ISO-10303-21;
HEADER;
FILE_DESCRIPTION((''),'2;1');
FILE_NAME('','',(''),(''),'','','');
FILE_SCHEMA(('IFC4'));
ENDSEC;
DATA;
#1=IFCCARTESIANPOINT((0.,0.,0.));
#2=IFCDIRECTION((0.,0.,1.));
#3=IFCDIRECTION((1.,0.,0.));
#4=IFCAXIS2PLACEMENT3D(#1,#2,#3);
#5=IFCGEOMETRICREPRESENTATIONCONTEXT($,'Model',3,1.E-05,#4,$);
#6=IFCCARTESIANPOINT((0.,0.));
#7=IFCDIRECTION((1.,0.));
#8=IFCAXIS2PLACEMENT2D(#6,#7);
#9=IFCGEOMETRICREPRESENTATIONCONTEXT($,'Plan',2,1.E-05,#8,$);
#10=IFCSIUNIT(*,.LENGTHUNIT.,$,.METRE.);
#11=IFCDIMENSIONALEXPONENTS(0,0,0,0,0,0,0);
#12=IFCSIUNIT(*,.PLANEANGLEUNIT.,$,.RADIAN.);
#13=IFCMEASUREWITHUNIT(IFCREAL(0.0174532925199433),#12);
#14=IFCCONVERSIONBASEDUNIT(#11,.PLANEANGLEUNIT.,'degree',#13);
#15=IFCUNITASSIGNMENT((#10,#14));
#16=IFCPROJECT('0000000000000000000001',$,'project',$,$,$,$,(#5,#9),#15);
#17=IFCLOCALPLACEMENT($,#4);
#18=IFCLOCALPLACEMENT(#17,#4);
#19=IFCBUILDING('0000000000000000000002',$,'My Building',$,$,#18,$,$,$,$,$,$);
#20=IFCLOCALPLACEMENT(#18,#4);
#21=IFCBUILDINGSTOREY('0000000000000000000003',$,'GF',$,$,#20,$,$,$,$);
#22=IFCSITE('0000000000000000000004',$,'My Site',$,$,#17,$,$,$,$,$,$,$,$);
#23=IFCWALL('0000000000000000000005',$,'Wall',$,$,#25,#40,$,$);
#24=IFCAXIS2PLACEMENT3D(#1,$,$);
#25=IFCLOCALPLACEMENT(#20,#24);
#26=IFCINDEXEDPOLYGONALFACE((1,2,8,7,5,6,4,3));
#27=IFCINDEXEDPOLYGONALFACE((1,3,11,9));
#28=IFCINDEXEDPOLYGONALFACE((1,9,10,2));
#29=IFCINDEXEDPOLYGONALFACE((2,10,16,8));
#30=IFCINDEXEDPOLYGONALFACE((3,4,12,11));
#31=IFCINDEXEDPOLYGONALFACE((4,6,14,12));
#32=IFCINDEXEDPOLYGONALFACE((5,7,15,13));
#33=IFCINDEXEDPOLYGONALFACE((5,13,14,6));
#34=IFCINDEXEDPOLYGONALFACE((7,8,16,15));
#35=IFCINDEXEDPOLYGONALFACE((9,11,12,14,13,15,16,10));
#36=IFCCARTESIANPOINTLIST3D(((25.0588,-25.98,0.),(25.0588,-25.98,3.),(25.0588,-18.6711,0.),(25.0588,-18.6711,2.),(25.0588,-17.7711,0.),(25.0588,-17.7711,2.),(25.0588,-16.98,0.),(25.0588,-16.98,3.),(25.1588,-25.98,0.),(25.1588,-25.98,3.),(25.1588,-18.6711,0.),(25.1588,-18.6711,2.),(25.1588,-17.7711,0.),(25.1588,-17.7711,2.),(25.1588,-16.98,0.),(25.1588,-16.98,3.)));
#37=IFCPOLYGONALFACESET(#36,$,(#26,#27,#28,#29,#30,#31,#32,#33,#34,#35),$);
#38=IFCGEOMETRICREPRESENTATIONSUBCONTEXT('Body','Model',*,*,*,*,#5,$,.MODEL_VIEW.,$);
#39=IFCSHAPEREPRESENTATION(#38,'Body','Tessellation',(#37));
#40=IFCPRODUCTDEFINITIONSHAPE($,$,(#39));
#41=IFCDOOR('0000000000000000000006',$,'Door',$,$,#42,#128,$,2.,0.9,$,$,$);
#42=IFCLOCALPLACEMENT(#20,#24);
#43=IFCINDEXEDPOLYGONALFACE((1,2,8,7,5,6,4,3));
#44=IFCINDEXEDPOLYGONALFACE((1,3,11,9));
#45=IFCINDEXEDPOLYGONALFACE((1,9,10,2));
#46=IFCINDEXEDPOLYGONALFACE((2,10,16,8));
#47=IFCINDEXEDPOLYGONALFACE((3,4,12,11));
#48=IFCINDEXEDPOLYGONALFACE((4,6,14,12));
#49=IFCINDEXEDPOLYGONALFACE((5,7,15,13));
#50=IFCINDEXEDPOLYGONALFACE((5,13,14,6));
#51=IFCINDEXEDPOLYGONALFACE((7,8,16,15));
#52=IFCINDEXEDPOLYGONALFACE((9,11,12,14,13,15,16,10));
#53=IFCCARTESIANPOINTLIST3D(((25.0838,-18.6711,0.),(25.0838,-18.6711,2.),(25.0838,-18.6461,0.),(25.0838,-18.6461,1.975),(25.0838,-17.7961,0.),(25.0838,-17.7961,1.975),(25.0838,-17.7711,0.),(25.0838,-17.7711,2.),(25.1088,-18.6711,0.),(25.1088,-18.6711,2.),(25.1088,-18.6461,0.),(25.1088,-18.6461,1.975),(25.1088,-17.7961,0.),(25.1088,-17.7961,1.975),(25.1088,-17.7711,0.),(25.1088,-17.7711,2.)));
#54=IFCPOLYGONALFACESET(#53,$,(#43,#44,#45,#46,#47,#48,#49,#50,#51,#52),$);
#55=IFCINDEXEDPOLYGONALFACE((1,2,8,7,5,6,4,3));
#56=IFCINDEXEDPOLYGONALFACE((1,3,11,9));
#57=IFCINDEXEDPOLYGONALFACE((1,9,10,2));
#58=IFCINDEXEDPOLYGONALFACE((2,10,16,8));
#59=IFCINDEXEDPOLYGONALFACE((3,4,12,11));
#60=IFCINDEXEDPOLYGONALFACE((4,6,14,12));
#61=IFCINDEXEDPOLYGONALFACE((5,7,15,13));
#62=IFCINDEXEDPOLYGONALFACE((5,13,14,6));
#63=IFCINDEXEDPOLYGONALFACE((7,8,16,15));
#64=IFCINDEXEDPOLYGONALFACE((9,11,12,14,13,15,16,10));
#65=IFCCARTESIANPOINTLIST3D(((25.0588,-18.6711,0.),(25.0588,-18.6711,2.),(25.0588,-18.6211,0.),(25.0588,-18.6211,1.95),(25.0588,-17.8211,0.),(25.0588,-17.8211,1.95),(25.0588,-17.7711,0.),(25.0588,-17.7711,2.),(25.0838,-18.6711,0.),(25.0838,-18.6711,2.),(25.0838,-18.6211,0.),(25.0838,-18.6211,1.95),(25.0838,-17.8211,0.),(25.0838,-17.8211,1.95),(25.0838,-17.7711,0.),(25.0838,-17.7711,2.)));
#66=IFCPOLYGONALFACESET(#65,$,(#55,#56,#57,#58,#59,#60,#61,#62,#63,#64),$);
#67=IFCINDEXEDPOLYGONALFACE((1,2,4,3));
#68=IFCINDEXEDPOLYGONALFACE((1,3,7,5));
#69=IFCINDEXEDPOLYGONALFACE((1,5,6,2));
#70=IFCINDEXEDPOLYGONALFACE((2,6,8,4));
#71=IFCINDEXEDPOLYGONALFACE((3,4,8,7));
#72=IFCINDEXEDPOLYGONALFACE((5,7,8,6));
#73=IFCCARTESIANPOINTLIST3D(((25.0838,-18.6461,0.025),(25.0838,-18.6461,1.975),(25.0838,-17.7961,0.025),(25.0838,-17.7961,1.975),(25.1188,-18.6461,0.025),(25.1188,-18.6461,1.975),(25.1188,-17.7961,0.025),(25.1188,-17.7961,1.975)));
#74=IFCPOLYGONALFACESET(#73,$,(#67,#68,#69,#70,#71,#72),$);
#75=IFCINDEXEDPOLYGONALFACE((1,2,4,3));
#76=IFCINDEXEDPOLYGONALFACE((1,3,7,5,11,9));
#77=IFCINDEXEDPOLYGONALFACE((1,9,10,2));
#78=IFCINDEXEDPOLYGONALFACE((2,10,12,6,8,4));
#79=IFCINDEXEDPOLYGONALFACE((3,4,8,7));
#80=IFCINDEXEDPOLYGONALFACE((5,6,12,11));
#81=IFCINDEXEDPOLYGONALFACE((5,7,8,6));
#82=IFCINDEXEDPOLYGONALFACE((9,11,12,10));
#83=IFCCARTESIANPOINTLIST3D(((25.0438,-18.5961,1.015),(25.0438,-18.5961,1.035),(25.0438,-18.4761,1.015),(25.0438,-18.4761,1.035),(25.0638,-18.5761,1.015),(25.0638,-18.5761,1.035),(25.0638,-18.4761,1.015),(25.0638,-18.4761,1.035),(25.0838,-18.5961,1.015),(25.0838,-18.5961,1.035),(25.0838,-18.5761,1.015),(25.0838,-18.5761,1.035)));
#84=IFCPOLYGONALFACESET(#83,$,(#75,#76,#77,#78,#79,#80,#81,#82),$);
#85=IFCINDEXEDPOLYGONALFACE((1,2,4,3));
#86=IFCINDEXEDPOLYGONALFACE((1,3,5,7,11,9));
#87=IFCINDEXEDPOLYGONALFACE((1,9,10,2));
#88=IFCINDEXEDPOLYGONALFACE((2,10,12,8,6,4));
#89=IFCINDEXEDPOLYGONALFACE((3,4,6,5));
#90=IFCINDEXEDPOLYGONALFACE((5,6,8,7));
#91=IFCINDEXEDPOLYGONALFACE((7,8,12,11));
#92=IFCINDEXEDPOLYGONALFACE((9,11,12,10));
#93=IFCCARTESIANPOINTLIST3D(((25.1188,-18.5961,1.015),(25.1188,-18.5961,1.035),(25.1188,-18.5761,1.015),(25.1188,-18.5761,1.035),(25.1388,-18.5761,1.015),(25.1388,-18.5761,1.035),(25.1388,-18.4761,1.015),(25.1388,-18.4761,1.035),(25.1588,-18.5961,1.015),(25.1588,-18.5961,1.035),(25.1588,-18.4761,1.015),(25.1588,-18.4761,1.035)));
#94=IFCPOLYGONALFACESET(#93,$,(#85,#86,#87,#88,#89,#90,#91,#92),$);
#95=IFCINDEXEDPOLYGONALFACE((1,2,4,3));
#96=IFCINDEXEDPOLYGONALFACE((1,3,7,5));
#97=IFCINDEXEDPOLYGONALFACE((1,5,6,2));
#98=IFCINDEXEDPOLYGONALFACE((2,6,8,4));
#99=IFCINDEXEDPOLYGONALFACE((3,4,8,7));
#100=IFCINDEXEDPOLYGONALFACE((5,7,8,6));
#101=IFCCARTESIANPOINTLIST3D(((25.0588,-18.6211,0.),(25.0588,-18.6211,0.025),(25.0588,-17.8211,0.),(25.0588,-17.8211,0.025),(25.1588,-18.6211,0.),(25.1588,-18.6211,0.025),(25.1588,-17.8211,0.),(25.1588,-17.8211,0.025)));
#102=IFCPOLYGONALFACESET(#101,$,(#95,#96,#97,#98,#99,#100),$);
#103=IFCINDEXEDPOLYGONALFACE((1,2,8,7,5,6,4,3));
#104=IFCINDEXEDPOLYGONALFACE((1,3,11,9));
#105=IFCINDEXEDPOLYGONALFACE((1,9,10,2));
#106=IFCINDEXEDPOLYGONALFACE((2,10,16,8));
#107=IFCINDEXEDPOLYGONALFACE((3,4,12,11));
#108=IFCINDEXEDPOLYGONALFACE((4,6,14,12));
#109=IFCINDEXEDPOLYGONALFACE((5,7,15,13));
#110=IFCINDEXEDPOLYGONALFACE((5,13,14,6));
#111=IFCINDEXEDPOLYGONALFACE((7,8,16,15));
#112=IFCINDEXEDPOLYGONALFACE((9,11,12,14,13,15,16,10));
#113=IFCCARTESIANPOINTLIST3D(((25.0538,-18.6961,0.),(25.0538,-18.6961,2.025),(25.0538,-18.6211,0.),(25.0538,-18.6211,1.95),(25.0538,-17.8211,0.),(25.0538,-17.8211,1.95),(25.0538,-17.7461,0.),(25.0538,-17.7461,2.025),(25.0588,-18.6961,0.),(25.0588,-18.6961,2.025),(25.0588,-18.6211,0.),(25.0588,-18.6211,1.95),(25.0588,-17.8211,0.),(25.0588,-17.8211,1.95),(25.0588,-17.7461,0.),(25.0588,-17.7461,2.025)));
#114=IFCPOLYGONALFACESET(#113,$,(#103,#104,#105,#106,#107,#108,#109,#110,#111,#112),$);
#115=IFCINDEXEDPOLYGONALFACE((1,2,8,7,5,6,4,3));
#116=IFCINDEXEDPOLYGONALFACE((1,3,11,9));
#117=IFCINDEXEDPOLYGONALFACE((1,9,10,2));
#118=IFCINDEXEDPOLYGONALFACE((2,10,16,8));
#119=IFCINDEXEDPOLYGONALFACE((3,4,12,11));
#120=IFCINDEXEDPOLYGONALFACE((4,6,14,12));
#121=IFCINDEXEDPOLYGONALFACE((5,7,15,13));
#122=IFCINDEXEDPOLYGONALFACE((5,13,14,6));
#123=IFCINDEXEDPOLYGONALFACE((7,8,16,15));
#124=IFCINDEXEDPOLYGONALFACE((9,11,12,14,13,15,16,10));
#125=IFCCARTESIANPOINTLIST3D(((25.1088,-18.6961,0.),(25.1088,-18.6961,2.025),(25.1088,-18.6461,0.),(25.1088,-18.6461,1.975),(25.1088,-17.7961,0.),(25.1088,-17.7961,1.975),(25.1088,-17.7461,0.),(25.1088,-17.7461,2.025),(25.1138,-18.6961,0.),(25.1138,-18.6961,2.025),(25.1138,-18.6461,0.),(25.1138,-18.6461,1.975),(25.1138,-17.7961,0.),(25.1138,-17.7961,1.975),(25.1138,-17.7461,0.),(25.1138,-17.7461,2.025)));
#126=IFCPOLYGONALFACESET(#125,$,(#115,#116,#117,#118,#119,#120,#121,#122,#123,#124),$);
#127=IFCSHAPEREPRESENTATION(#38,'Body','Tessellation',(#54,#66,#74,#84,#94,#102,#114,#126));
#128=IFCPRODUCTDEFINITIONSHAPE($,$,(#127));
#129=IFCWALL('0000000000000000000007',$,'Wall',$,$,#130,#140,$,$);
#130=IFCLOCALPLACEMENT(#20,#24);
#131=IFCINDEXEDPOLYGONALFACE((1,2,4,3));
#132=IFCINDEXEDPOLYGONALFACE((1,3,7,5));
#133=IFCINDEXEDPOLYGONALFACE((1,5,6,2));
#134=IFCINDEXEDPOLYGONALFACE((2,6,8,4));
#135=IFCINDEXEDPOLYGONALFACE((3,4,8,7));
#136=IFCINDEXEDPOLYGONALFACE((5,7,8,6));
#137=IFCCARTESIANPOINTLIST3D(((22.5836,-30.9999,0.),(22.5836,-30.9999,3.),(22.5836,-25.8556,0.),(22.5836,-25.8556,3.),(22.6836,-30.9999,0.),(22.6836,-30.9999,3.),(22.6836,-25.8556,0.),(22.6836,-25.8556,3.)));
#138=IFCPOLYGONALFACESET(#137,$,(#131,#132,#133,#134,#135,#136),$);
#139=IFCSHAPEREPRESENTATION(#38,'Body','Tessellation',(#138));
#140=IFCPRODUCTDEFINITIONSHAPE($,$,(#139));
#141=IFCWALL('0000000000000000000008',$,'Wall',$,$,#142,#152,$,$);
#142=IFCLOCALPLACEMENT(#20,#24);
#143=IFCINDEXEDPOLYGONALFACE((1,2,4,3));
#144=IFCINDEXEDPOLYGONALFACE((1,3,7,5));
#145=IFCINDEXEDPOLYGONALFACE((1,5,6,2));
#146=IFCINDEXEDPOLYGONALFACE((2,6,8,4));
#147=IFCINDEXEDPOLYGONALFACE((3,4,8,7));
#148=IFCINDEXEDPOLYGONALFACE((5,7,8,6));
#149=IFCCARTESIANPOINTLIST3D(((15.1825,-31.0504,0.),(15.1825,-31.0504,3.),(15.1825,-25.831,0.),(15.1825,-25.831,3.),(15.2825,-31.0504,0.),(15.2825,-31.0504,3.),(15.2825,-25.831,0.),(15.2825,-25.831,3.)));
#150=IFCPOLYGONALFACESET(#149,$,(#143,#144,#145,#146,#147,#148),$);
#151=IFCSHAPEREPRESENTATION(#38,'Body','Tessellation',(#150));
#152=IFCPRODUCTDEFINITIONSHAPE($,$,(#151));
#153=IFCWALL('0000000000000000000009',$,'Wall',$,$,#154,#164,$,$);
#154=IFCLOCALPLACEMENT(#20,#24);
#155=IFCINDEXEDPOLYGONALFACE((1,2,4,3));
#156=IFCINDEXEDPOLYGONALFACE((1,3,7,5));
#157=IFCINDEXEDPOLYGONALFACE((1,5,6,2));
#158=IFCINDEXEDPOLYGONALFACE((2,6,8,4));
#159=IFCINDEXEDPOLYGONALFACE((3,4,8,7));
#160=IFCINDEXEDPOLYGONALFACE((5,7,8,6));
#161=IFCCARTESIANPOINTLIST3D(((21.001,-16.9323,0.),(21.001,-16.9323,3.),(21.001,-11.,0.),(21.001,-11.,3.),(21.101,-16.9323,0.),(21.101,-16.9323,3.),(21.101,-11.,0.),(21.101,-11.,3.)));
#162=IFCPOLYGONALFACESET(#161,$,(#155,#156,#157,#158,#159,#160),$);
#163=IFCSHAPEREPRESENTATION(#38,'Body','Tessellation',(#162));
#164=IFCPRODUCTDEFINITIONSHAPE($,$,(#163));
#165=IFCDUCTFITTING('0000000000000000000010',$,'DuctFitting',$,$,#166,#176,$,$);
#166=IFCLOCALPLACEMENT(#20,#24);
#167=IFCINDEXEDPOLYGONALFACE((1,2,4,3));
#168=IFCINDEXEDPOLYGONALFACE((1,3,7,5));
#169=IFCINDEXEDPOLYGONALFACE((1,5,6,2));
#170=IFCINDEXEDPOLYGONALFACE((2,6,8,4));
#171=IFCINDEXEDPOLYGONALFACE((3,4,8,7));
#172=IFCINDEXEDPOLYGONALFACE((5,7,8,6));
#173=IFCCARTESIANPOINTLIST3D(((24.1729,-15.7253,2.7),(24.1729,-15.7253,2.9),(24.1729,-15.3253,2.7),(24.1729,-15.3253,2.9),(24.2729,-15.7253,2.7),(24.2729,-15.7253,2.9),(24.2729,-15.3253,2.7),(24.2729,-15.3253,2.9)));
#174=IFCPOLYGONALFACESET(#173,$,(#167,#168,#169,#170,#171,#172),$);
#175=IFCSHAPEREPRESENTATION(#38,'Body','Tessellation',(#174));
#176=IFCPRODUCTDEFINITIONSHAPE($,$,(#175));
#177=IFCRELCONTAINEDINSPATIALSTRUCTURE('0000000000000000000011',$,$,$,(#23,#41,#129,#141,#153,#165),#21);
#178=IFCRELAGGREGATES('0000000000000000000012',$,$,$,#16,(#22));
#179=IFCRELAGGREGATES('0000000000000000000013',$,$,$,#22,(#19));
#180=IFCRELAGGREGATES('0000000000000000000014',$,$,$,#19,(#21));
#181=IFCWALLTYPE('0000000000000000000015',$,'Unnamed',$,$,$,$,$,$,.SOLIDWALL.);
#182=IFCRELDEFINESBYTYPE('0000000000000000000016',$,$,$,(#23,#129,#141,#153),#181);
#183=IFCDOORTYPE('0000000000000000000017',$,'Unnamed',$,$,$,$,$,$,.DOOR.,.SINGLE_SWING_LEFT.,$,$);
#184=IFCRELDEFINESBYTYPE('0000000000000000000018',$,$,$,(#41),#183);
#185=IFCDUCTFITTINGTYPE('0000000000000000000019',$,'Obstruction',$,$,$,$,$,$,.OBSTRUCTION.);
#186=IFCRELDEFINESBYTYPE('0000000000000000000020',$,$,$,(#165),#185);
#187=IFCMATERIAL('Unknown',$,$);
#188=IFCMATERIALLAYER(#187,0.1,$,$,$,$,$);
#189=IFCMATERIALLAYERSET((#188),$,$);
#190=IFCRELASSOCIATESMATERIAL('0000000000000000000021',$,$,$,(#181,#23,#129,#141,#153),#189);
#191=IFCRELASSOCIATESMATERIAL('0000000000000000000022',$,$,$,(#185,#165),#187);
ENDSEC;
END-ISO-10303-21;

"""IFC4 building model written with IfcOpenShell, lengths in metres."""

from ifc_helpers import new_model, entity, si_unit, converted_unit, frame, origin_with_axes, origin_2d_with_axis, place, context, subcontext, project, spatial, line, indexed_curve, rectangle, outline, extrude, shape, source, transform, mapped, material, layer, layer_set, layer_usage, material_profile, profile_set, profile_usage, type_object, type_shapes, element, fill, save


model = new_model("IFC4")

# Units and contexts
model_context = context("Model", 3, precision=1e-05, world=origin_with_axes())
plan_context = context("Plan", 2, precision=1e-05, world=origin_2d_with_axis())
body_context_1 = subcontext(model_context, "Body", "Model", "MODEL_VIEW")
body_context_2 = subcontext(plan_context, "Body", "Plan", "PLAN_VIEW")
ifc_project = project(units=[si_unit("LENGTHUNIT", "METRE"), converted_unit("PLANEANGLEUNIT", "degree", entity("IfcReal", 0.0174532925199433), si_unit("PLANEANGLEUNIT", "RADIAN"), dimensions=[0, 0, 0, 0, 0, 0, 0])], contexts=[model_context, plan_context])

# Site, building, storey
site_placement = place(None, origin_with_axes())
site = spatial("IfcSite", under=ifc_project, at=site_placement, Name="My Site")
building_placement = place(site_placement, origin_with_axes())
building = spatial("IfcBuilding", under=site, at=building_placement, Name="My Building")
storey_placement = place(building_placement, origin_with_axes())
storey = spatial("IfcBuildingStorey", under=building, at=storey_placement, Name="GF")

# Shared definitions
ifc_material = material(Name="Unknown")
ifc_layer = layer(ifc_material, 0.1)
ifc_layer_set = layer_set([ifc_layer])
wall_type = type_object("IfcWallType", Name="Unnamed", PredefinedType="SOLIDWALL", material=ifc_layer_set)

# Shared definitions
shared_shape_1 = source(origin_with_axes(), body_context_1, "Body", "SweptSolid", [
    extrude(outline(indexed_curve([(0.0, 0.0), (0.9, 0.0), (0.9, 2.0), (0.0, 2.0)], segments=[line(1, 2, 3, 4, 1)])), frame((0.0, -0.6, 0.0), z_axis=(0.0, -1.0, 0.0), x_axis=(1.0, 0.0, 0.0)), (0.0, 0.0, -1.0), 1.2),
])
door_type = type_object("IfcDoorType", Name="Unnamed", OperationType="SINGLE_SWING_LEFT", PredefinedType="DOOR")
shared_shape_2 = source(origin_with_axes(), body_context_1, "Body", "SweptSolid", [
    extrude(outline(indexed_curve([(0.0, 0.0), (0.0, 2.0), (0.9, 2.0), (0.9, 0.0), (0.875, 0.0), (0.875, 1.975), (0.025, 1.975), (0.025, 0.0)], segments=[line(1, 2, 3, 4, 5, 6, 7, 8, 1)])), frame((0.0, 0.025, 0.0), z_axis=(0.0, -1.0, 0.0), x_axis=(1.0, 0.0, 0.0)), (0.0, 0.0, -1.0), 0.025),
    extrude(outline(indexed_curve([(0.0, 0.0), (0.0, 2.0), (0.9, 2.0), (0.9, 0.0), (0.85, 0.0), (0.85, 1.95), (0.05, 1.95), (0.05, 0.0)], segments=[line(1, 2, 3, 4, 5, 6, 7, 8, 1)])), frame((0.0, 0.0, 0.0), z_axis=(0.0, -1.0, 0.0), x_axis=(1.0, 0.0, 0.0)), (0.0, 0.0, -1.0), 0.025),
    extrude(outline(indexed_curve([(0.0, 0.0), (0.85, 0.0), (0.85, 0.035), (0.0, 0.035)], segments=[line(1, 2, 3, 4, 1)])), frame((0.025, 0.025, 0.025), z_axis=(0.0, 0.0, 1.0), x_axis=(1.0, 0.0, 0.0)), (0.0, 0.0, 1.0), 1.95),
    extrude(outline(indexed_curve([(0.0, 0.0), (0.0, -0.04), (-0.12, -0.04), (-0.12, -0.02), (-0.02, -0.02), (-0.02, 0.0)], segments=[line(1, 2, 3, 4, 5, 6, 1)])), frame((0.825, 0.025, 1.015), z_axis=(0.0, 0.0, 1.0), x_axis=(1.0, 0.0, 0.0)), (0.0, 0.0, 1.0), 0.02),
    extrude(outline(indexed_curve([(0.0, 0.0), (0.0, 0.04), (-0.12, 0.04), (-0.12, 0.02), (-0.02, 0.02), (-0.02, 0.0)], segments=[line(1, 2, 3, 4, 5, 6, 1)])), frame((0.825, 0.06, 1.015), z_axis=(0.0, 0.0, 1.0), x_axis=(1.0, 0.0, 0.0)), (0.0, 0.0, 1.0), 0.02),
    extrude(outline(indexed_curve([(0.0, 0.0), (0.8, 0.0), (0.8, 0.1), (0.0, 0.1)], segments=[line(1, 2, 3, 4, 1)])), frame((0.05, 0.0, 0.0), z_axis=(0.0, 0.0, 1.0), x_axis=(1.0, 0.0, 0.0)), (0.0, 0.0, 1.0), 0.025),
    extrude(outline(indexed_curve([(0.0, 0.0), (0.0, 2.025), (0.95, 2.025), (0.95, 0.0), (0.875, 0.0), (0.875, 1.95), (0.075, 1.95), (0.075, 0.0)], segments=[line(1, 2, 3, 4, 5, 6, 7, 8, 1)])), frame((-0.025, -0.005, 0.0), z_axis=(0.0, -1.0, 0.0), x_axis=(1.0, 0.0, 0.0)), (0.0, 0.0, -1.0), 0.005),
    extrude(outline(indexed_curve([(0.0, 0.0), (0.0, 2.025), (0.95, 2.025), (0.95, 0.0), (0.9, 0.0), (0.9, 1.975), (0.05, 1.975), (0.05, 0.0)], segments=[line(1, 2, 3, 4, 5, 6, 7, 8, 1)])), frame((-0.025, 0.05, 0.0), z_axis=(0.0, -1.0, 0.0), x_axis=(1.0, 0.0, 0.0)), (0.0, 0.0, -1.0), 0.005),
])
shared_shape_3 = source(origin_with_axes(), body_context_2, "Body", "Curve2D", [
    entity("IfcIndexedPolyCurve", entity("IfcCartesianPointList2D", [[0.0, 0.0], [0.0, 0.05], [0.025, 0.05], [0.025, 0.025], [0.05, 0.025], [0.05, 0.0]]), [entity("IfcLineIndex", [1, 2, 3, 4, 5, 6, 1])]),
    entity("IfcIndexedPolyCurve", entity("IfcCartesianPointList2D", [[0.9, 0.0], [0.9, 0.05], [0.875, 0.05], [0.875, 0.025], [0.85, 0.025], [0.85, 0.0]]), [entity("IfcLineIndex", [1, 2, 3, 4, 5, 6, 1])]),
    entity("IfcTrimmedCurve", entity("IfcEllipse", entity("IfcAxis2Placement2D", entity("IfcCartesianPoint", [0.06, 0.05]), entity("IfcDirection", [1.0, 0.0])), 0.815, 0.85), [entity("IfcCartesianPoint", [0.875, 0.05])], [entity("IfcCartesianPoint", [0.06, 0.9])], True, "CARTESIAN"),
    entity("IfcIndexedPolyCurve", entity("IfcCartesianPointList2D", [[0.025, 0.05], [0.06, 0.05], [0.06, 0.9], [0.025, 0.9]]), [entity("IfcLineIndex", [1, 2, 3, 4, 1])]),
])
type_shapes(door_type, [shared_shape_2, shared_shape_3])

# Wall, opening, door
ifc_layer_usage_1 = layer_usage(ifc_layer_set, "AXIS2", "POSITIVE", 0.0)
wall_1_placement = place(storey_placement, frame((25.0588, -16.98, 0.0), z_axis=(0.0, 0.0, 1.0), x_axis=(0.0, -1.0, 0.0)))
wall_1 = element("IfcWall", 1, at=wall_1_placement, inside=storey, type_object=wall_type, material=ifc_layer_usage_1, Name="Wall", context=body_context_1, shape_type="SweptSolid", body=[
    extrude(outline(indexed_curve([(0.0, 0.0), (0.0, 0.1), (9.0, 0.1), (9.0, 0.0)], segments=[line(1, 2, 3, 4, 1)])), origin_with_axes(), (0.0, 0.0, 1.0), 3.0),
])
opening_1_placement = place(wall_1_placement, frame((0.7911, 0.0, 0.0), z_axis=(0.0, 0.0, 1.0), x_axis=(1.0, 0.0, 0.0)))
opening_1 = element("IfcOpeningElement", 2, at=opening_1_placement, cuts=wall_1, PredefinedType="OPENING", context=body_context_1, shape_type="MappedRepresentation", body=[
    mapped(shared_shape_1, transform((0.0, 0.0, 0.0), x_axis=(1.0, 0.0, 0.0), y_axis=(0.0, 1.0, 0.0), z_axis=(0.0, 0.0, 1.0), scale=1.0)),
])
door_1_placement = place(opening_1_placement, frame((0.0, 0.0, 0.0), z_axis=(0.0, 0.0, 1.0), x_axis=(1.0, 0.0, 0.0)))
door_1 = element("IfcDoor", 3, at=door_1_placement, inside=storey, type_object=door_type, Name="Door", OverallHeight=2.0, OverallWidth=0.9, shapes=[
    shape(body_context_1, "Body", "MappedRepresentation", [mapped(shared_shape_2, transform((0.0, 0.0, 0.0), x_axis=(1.0, 0.0, 0.0), y_axis=(0.0, 1.0, 0.0), z_axis=(0.0, 0.0, 1.0), scale=1.0))]),
    shape(body_context_2, "Body", "MappedRepresentation", [mapped(shared_shape_3, transform((0.0, 0.0, 0.0), x_axis=(1.0, 0.0, 0.0), y_axis=(0.0, 1.0, 0.0), z_axis=(0.0, 0.0, 1.0), scale=1.0))]),
])
fill(opening_1, door_1)

# Walls
ifc_layer_usage_2 = layer_usage(ifc_layer_set, "AXIS2", "POSITIVE", 0.0)
wall_2_placement = place(storey_placement, frame((22.5836, -25.8556, 0.0), z_axis=(0.0, 0.0, 1.0), x_axis=(0.0, -1.0, 0.0)))
element("IfcWall", 4, at=wall_2_placement, inside=storey, type_object=wall_type, material=ifc_layer_usage_2, Name="Wall", context=body_context_1, shape_type="SweptSolid", body=[
    extrude(outline(indexed_curve([(0.0, 0.0), (0.0, 0.1), (5.1443, 0.1), (5.1443, 0.0)], segments=[line(1, 2, 3, 4, 1)])), origin_with_axes(), (0.0, 0.0, 1.0), 3.0),
])
ifc_layer_usage_3 = layer_usage(ifc_layer_set, "AXIS2", "POSITIVE", 0.0)
wall_3_placement = place(storey_placement, frame((15.1825, -25.831, 0.0), z_axis=(0.0, 0.0, 1.0), x_axis=(0.0, -1.0, 0.0)))
element("IfcWall", 5, at=wall_3_placement, inside=storey, type_object=wall_type, material=ifc_layer_usage_3, Name="Wall", context=body_context_1, shape_type="SweptSolid", body=[
    extrude(outline(indexed_curve([(0.0, 0.0), (0.0, 0.1), (5.2194, 0.1), (5.2194, 0.0)], segments=[line(1, 2, 3, 4, 1)])), origin_with_axes(), (0.0, 0.0, 1.0), 3.0),
])
ifc_layer_usage_4 = layer_usage(ifc_layer_set, "AXIS2", "POSITIVE", 0.0)
wall_4_placement = place(storey_placement, frame((21.101, -16.9323, 0.0), z_axis=(0.0, 0.0, 1.0), x_axis=(0.0, 1.0, 0.0)))
element("IfcWall", 6, at=wall_4_placement, inside=storey, type_object=wall_type, material=ifc_layer_usage_4, Name="Wall", context=body_context_1, shape_type="SweptSolid", body=[
    extrude(outline(indexed_curve([(0.0, 0.0), (0.0, 0.1), (5.9323, 0.1), (5.9323, 0.0)], segments=[line(1, 2, 3, 4, 1)])), origin_with_axes(), (0.0, 0.0, 1.0), 3.0),
])

# Duct fitting
ifc_material_profile = material_profile(ifc_material, rectangle(XDim=0.4, YDim=0.2))
ifc_profile_set = profile_set([ifc_material_profile])
ifc_profile_usage_1 = profile_usage(ifc_profile_set, cardinal=5)
duct_fitting_type = type_object("IfcDuctFittingType", Name="Obstruction", PredefinedType="OBSTRUCTION", material=ifc_profile_set)
duct_fitting_1_placement = place(storey_placement, frame((24.2729, -15.5253, 2.8), z_axis=(-1.0, 0.0, 0.0), x_axis=(0.0, -1.0, 0.0)))
element("IfcDuctFitting", 7, at=duct_fitting_1_placement, inside=storey, type_object=duct_fitting_type, material=ifc_profile_usage_1, Name="DuctFitting", context=body_context_1, shape_type="SweptSolid", body=[
    extrude(rectangle(XDim=0.4, YDim=0.2), origin_with_axes(), (0.0, 0.0, 1.0), 0.1),
])

save(model, "model.ifc")
